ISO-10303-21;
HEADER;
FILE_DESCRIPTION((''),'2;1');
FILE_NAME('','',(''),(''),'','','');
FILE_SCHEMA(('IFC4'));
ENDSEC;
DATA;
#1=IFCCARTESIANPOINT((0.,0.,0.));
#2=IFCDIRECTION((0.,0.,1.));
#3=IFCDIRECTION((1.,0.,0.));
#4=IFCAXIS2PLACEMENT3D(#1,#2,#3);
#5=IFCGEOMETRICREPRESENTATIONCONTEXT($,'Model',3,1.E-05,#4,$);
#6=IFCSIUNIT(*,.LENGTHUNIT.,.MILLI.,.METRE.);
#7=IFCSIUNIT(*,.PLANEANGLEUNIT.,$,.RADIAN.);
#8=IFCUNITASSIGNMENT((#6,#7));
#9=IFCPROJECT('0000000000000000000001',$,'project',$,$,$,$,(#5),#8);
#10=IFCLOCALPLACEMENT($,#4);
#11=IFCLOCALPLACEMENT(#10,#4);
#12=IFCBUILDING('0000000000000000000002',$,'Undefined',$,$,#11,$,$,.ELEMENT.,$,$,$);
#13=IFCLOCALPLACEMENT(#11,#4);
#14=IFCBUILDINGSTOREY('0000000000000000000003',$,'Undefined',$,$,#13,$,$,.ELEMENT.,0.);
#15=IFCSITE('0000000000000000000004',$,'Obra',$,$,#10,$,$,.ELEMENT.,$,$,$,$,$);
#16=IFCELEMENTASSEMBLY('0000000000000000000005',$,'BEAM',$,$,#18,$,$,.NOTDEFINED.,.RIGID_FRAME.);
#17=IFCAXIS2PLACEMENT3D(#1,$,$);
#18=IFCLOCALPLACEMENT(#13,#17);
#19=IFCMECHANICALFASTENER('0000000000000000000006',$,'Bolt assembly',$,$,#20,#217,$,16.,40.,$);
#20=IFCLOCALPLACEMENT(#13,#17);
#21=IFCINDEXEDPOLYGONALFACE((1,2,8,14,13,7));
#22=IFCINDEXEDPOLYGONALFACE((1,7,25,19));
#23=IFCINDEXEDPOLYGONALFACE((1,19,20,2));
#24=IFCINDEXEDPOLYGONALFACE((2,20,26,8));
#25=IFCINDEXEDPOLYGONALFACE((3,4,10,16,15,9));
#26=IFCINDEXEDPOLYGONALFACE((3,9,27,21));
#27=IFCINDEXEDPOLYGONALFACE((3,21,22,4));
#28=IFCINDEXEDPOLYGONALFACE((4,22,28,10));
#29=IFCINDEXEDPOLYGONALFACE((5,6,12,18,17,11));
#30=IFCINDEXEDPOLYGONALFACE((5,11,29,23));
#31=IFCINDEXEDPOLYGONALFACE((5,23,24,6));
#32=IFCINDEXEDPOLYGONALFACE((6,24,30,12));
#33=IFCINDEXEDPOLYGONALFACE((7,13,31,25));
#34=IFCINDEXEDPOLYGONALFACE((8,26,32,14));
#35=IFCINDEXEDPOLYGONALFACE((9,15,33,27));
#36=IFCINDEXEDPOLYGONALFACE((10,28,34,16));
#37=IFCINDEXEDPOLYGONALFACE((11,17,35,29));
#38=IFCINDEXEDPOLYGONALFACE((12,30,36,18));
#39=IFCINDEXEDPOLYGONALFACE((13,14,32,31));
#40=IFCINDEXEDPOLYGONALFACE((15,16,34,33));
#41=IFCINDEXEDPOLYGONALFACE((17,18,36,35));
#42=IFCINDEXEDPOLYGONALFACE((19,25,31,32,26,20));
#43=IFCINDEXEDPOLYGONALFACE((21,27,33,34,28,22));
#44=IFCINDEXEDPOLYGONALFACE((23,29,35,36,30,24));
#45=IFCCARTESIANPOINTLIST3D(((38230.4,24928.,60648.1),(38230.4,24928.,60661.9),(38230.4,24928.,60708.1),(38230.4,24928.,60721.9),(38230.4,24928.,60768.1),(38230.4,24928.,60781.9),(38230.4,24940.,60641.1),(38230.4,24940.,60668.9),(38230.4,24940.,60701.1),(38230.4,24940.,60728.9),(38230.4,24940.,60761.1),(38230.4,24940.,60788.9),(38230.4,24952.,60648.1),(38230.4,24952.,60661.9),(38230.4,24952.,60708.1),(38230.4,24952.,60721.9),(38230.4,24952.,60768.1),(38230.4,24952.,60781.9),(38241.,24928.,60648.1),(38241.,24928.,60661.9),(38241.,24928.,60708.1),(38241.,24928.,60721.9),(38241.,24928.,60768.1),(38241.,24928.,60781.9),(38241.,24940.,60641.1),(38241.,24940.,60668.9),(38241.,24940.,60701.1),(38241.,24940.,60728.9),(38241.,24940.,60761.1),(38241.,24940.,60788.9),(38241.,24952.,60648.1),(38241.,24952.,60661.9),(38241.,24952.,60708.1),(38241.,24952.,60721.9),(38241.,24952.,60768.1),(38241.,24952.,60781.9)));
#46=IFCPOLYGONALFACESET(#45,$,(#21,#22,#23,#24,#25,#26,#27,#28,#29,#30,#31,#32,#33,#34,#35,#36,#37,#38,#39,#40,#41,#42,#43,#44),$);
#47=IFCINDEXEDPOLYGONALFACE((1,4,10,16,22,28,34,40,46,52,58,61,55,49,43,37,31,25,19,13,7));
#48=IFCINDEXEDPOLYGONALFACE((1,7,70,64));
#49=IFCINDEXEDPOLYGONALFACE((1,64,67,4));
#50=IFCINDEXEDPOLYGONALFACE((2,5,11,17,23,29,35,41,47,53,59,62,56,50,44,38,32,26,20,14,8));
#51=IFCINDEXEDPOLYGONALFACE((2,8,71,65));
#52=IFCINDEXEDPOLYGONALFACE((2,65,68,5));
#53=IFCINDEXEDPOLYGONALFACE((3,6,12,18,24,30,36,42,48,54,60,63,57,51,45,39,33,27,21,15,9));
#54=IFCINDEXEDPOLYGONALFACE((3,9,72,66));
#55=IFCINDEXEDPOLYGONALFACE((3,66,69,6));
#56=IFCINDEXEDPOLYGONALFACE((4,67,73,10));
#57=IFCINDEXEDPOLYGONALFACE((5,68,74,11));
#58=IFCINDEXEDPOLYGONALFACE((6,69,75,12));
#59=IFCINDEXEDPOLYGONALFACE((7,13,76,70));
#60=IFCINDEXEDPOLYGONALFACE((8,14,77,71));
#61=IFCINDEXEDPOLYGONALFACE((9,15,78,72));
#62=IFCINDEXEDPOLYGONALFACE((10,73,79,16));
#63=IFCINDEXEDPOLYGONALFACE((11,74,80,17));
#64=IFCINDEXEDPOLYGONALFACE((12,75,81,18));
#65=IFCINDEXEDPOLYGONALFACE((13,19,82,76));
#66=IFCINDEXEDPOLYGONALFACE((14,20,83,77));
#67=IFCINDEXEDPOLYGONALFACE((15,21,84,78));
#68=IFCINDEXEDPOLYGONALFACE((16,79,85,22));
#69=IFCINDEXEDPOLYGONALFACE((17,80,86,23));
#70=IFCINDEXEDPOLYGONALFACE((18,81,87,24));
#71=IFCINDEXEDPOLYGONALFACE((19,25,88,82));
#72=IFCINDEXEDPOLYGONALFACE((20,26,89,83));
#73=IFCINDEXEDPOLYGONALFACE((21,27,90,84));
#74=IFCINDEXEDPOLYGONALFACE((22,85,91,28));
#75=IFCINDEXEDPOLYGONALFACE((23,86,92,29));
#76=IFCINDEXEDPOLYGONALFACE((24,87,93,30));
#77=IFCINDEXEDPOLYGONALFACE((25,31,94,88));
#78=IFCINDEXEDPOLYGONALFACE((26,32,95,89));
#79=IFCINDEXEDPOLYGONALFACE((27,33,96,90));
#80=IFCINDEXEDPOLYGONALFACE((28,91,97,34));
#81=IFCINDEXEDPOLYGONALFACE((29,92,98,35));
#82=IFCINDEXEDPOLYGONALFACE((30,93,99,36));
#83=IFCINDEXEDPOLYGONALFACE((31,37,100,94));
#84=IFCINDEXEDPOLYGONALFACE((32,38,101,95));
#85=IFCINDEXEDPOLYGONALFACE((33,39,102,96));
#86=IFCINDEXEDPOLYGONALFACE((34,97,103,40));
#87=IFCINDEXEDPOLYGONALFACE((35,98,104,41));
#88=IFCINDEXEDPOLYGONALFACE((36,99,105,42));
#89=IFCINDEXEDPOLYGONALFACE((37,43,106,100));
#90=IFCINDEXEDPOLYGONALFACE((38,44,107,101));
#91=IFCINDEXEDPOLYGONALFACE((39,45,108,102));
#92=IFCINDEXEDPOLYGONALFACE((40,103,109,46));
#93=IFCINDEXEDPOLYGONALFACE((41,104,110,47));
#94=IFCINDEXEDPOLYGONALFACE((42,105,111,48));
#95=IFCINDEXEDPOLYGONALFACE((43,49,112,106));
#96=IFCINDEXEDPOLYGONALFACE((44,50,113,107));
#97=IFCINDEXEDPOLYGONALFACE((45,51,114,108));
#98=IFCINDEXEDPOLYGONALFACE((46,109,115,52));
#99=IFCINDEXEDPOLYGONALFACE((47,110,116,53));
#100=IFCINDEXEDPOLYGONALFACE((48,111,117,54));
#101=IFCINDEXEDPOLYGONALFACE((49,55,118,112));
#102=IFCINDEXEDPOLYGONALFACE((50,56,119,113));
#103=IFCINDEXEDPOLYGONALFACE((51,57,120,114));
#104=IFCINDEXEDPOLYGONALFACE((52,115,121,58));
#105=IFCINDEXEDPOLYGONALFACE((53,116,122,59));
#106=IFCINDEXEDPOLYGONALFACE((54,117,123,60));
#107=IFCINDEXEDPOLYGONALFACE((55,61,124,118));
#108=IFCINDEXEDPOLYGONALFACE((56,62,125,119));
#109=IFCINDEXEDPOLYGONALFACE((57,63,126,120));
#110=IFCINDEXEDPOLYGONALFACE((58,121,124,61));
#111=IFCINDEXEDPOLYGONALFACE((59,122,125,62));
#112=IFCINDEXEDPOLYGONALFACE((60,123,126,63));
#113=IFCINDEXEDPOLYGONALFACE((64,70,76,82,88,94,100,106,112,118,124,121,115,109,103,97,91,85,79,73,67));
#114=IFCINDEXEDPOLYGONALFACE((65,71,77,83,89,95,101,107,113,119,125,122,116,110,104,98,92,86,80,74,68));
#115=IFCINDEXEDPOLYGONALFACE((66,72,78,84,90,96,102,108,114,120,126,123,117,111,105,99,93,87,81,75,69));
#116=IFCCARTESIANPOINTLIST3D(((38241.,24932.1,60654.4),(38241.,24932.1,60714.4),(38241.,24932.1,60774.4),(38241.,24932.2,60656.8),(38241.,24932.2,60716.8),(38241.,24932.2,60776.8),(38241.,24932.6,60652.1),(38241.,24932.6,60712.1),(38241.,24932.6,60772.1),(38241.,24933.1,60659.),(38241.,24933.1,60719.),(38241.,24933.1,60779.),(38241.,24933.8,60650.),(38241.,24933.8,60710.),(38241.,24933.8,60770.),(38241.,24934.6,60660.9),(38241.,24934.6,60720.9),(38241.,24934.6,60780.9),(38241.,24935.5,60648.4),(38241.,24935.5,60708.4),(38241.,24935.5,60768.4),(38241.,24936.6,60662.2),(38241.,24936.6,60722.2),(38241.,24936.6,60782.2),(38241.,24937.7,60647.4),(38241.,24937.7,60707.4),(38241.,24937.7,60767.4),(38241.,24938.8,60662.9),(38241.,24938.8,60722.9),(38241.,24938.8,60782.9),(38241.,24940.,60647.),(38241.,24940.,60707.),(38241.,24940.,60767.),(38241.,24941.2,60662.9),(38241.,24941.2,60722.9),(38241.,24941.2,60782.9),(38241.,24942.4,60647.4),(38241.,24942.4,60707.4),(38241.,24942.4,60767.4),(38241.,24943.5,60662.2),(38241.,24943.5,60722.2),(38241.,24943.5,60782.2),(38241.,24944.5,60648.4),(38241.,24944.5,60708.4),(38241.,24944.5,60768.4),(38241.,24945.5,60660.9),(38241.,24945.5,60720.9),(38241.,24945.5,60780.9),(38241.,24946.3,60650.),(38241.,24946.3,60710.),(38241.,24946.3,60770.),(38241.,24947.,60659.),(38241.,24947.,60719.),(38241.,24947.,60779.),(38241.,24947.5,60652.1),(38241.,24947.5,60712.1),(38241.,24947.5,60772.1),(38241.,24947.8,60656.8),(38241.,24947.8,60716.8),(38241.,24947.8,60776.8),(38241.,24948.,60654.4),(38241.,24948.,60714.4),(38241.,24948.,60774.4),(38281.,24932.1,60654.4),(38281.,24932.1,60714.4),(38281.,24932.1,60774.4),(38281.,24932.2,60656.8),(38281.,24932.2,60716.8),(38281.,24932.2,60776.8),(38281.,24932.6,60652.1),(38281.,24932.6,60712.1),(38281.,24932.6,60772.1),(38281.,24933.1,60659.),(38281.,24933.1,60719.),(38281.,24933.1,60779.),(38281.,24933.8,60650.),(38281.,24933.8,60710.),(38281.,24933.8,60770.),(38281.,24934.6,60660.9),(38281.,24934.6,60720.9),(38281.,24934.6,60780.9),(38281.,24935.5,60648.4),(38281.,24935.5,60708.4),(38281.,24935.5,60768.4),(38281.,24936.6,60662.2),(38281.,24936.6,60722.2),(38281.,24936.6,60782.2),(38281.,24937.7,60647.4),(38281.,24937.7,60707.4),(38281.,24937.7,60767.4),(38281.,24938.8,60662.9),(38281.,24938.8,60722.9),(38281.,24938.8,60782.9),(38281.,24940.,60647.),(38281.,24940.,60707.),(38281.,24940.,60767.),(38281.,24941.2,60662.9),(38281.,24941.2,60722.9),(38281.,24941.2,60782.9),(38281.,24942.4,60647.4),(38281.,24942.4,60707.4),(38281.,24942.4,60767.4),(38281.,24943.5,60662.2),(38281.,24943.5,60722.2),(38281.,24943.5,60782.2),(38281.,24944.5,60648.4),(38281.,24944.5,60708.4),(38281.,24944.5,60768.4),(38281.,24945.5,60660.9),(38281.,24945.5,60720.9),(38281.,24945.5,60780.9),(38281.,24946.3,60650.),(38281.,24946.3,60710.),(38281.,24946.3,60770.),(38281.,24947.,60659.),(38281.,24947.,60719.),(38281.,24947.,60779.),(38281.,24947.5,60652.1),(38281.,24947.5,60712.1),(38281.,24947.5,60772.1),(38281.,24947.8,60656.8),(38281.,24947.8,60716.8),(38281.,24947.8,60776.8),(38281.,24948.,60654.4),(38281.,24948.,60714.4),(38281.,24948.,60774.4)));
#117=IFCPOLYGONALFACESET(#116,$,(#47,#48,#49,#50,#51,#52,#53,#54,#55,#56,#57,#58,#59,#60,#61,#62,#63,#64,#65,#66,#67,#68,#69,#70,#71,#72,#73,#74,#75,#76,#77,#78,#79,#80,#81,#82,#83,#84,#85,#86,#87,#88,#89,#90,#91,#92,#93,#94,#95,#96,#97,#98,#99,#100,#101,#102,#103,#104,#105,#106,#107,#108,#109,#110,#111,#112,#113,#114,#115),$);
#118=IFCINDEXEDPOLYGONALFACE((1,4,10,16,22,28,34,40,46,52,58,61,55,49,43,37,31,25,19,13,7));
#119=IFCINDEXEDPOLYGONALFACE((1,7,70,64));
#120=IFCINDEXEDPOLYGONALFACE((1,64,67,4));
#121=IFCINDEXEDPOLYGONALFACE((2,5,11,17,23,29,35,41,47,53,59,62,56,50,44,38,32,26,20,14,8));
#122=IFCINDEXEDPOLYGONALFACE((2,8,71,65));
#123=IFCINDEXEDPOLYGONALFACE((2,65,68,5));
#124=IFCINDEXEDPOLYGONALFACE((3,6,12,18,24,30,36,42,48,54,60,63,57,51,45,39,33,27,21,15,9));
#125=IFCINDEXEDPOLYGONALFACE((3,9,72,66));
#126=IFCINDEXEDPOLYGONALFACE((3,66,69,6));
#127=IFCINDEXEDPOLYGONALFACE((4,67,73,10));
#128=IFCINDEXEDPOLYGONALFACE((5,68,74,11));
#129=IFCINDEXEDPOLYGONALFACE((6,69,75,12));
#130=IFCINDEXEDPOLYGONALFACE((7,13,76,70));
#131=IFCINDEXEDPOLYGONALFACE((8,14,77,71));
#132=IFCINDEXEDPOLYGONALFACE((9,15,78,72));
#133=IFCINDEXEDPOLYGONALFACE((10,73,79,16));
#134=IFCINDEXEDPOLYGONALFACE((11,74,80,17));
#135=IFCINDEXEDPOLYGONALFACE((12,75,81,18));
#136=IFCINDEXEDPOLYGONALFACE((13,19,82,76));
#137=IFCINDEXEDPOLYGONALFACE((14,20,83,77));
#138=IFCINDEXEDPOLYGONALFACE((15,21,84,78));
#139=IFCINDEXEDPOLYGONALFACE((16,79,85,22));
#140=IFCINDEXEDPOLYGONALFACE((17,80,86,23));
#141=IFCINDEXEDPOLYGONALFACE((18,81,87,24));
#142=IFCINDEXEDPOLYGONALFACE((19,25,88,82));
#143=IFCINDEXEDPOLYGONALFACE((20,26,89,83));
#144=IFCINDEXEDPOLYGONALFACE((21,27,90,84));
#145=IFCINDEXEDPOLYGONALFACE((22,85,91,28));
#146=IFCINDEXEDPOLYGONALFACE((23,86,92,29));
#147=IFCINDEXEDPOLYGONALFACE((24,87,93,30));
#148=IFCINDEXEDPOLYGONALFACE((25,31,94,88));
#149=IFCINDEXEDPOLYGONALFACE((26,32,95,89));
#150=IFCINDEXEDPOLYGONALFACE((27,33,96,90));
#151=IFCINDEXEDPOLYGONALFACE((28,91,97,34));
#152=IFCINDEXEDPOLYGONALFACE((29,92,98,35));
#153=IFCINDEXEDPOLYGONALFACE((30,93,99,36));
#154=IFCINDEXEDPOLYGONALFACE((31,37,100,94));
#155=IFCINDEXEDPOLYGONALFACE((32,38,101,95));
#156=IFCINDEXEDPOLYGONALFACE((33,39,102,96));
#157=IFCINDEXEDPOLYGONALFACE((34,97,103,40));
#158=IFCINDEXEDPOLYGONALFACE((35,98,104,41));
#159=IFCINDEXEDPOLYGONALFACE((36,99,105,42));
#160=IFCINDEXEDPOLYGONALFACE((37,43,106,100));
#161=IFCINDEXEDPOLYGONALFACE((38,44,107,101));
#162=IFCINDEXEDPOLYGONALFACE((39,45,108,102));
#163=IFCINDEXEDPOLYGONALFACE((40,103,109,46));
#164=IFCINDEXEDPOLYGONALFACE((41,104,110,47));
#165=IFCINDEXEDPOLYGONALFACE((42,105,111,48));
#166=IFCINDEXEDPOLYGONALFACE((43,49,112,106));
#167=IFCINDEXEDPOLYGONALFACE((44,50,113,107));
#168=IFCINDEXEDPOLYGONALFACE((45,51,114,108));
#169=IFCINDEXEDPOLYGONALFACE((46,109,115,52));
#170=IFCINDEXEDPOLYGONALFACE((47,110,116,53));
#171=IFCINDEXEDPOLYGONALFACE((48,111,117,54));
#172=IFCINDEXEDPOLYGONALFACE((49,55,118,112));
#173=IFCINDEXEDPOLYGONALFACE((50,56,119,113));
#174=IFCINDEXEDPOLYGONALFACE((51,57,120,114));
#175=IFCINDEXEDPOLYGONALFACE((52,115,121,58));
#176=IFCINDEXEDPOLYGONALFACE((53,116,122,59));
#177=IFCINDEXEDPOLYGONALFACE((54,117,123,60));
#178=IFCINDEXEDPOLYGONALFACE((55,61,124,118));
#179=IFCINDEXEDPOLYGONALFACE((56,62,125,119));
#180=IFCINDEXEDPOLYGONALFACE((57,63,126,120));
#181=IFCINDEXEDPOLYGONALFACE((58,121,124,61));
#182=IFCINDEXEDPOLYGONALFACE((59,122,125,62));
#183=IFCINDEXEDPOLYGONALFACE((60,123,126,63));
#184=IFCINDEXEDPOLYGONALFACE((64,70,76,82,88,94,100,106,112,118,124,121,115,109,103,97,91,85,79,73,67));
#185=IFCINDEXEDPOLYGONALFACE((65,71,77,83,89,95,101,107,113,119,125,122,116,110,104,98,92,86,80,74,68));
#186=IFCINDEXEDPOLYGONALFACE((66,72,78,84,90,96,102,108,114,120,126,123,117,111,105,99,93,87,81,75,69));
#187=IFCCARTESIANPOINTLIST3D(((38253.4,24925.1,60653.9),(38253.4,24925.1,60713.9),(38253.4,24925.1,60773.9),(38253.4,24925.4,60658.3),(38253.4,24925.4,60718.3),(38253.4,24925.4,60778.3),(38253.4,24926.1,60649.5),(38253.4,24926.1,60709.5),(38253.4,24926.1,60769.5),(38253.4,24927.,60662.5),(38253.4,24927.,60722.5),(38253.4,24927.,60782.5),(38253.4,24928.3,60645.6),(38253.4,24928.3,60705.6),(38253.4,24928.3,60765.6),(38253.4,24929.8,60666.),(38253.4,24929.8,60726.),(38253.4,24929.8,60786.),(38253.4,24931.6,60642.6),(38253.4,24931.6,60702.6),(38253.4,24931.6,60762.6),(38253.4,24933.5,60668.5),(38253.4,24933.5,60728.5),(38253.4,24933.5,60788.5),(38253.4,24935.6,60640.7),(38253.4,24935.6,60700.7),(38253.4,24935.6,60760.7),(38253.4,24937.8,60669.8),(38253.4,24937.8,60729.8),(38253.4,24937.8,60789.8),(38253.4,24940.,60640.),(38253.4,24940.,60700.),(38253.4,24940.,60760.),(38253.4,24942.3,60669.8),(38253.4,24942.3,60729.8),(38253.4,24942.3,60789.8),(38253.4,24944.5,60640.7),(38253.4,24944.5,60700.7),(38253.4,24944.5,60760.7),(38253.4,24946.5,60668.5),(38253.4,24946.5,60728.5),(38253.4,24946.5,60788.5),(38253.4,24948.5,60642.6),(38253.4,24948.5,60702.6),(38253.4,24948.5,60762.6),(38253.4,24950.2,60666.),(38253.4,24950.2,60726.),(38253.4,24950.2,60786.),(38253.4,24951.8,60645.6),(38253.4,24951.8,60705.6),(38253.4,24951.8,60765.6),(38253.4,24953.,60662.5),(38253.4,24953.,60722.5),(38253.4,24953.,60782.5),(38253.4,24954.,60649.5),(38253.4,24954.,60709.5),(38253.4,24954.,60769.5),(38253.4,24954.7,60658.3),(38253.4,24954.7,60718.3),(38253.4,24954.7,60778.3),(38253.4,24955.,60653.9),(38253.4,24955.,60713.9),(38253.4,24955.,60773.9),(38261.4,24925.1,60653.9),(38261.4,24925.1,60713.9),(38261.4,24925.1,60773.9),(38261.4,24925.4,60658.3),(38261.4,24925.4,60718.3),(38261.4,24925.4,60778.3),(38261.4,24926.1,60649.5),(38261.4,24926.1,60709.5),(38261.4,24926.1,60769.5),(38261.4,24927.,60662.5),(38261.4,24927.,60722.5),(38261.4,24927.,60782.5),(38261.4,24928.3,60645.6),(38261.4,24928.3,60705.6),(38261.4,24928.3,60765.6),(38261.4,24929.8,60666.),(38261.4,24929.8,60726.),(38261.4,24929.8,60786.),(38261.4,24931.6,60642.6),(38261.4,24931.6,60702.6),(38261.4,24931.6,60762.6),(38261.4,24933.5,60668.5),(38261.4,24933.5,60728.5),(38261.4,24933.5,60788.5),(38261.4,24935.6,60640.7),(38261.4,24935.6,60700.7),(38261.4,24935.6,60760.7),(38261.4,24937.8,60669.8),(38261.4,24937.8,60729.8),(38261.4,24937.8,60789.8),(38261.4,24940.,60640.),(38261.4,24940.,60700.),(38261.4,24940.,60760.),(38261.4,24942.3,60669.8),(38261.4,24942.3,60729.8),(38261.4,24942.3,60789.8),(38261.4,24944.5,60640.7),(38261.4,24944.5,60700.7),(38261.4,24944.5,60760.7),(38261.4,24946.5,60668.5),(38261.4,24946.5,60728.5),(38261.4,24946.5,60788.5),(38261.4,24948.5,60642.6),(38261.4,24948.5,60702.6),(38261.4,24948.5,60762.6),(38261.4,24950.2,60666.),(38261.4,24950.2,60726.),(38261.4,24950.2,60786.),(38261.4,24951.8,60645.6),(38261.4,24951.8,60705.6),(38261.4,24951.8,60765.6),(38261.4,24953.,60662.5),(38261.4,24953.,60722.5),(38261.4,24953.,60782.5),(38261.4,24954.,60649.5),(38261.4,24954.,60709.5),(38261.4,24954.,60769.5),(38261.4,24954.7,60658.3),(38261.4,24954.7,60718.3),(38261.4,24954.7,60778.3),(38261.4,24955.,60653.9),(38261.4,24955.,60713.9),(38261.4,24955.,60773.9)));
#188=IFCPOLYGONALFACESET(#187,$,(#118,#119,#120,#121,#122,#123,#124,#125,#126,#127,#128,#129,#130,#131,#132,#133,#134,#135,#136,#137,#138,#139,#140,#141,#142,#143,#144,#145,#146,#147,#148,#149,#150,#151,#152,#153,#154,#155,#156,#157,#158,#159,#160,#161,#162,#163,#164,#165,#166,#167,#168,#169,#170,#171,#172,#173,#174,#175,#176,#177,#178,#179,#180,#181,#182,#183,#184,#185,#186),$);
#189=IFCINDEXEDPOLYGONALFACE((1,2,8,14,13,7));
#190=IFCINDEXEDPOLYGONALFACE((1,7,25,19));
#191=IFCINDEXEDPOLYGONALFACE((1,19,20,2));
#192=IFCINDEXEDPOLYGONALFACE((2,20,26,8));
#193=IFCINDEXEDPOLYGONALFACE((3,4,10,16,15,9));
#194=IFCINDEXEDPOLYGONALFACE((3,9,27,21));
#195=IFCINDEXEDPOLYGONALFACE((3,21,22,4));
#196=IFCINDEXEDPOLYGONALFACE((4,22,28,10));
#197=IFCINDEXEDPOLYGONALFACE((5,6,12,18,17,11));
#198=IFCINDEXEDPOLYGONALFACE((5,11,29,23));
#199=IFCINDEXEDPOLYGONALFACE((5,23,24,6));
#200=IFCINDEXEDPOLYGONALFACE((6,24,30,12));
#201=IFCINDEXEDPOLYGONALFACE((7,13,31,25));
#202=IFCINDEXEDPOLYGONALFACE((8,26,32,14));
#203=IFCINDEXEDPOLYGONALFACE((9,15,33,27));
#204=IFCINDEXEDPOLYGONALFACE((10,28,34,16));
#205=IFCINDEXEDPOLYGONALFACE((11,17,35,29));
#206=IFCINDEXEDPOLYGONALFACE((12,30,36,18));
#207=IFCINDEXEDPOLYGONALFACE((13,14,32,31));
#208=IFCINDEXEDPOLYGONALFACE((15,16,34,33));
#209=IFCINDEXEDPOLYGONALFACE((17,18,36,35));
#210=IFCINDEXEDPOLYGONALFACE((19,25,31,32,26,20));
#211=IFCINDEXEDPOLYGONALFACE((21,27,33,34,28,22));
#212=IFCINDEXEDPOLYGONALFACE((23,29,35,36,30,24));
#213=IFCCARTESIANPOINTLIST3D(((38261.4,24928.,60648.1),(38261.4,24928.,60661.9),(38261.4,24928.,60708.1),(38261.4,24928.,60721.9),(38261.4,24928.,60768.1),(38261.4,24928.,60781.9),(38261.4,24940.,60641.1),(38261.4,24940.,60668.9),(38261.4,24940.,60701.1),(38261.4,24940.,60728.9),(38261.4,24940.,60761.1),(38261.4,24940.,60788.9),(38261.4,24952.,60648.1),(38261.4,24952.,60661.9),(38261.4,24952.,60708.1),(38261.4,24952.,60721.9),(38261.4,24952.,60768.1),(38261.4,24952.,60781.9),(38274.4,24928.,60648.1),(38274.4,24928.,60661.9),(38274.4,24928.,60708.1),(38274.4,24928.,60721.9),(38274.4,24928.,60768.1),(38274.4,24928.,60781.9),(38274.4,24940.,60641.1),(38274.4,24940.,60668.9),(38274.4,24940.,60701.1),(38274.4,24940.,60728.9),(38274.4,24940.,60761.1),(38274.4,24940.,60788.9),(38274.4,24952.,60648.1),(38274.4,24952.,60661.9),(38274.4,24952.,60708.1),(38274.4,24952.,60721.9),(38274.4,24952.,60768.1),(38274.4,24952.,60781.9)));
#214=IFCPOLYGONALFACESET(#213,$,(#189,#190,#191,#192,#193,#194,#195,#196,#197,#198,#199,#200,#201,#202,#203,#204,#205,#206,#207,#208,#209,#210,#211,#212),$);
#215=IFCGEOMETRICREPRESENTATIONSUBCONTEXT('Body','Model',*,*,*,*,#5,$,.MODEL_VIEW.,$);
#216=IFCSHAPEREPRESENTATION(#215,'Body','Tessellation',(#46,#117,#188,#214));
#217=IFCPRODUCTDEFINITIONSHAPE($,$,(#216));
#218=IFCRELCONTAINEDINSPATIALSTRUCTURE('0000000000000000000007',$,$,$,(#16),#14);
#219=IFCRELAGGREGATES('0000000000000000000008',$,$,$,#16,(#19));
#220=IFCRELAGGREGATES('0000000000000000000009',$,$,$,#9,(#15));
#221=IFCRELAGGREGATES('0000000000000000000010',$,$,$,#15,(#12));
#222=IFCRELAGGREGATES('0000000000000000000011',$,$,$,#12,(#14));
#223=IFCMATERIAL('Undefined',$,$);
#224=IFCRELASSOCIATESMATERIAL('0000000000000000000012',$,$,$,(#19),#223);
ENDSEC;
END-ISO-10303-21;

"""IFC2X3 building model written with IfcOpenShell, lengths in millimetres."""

from ifc_helpers import new_model, si_unit, frame, origin_with_axes, origin_2d_with_axis, place, context, subcontext, project, spatial, polyline, circle, outline, extrude, source, transform, mapped, material, element, aggregate, save


model = new_model("IFC2X3")

# Units and contexts
model_context = context("Model", 3, precision=1e-05, world=origin_with_axes())
body_context = subcontext(model_context, "Body", "Model", "MODEL_VIEW")
ifc_project = project(units=[si_unit("LENGTHUNIT", "METRE", prefix="MILLI"), si_unit("PLANEANGLEUNIT", "RADIAN")], contexts=[model_context])

# Site, building, storey
site_placement = place(None, origin_with_axes())
site = spatial("IfcSite", under=ifc_project, at=site_placement, Name="Obra", CompositionType="ELEMENT")
building_placement = place(site_placement, origin_with_axes())
building = spatial("IfcBuilding", under=site, at=building_placement, Name="Undefined", CompositionType="ELEMENT")
storey_placement = place(building_placement, origin_with_axes())
storey = spatial("IfcBuildingStorey", under=building, at=storey_placement, Name="Undefined", CompositionType="ELEMENT", Elevation=0.0)

# Element assembly
ifc_material_1 = material(Name="Undefined")
assembly_1_placement = place(storey_placement, origin_with_axes())
assembly_1 = element("IfcElementAssembly", 1, at=assembly_1_placement, inside=storey, Name="BEAM", AssemblyPlace="NOTDEFINED", PredefinedType="RIGID_FRAME")

# Mechanical fastener
shared_shape_1 = source(origin_with_axes(), body_context, "Body", "SweptSolid", [
    extrude(outline(polyline([(13.9, 0.0), (6.9, 12.0), (-6.9, 12.0), (-13.9, 0.0), (-6.9, -12.0), (6.9, -12.0), (13.9, 0.0)])), frame((0.0, -19.7, 0.0), z_axis=(0.0, 1.0, 0.0), x_axis=(1.0, 0.0, 0.0)), (0.0, 0.0, 1.0), 10.6),
    extrude(circle(Radius=8.0, at=origin_2d_with_axis()), frame((0.0, -9.1, 0.0), z_axis=(0.0, 1.0, 0.0), x_axis=(1.0, 0.0, 0.0)), (0.0, 0.0, 1.0), 40.0),
    extrude(circle(Radius=15.0, at=origin_2d_with_axis()), frame((0.0, 3.3, 0.0), z_axis=(0.0, 1.0, 0.0), x_axis=(1.0, 0.0, 0.0)), (0.0, 0.0, 1.0), 8.0),
    extrude(outline(polyline([(13.9, 0.0), (6.9, 12.0), (-6.9, 12.0), (-13.9, 0.0), (-6.9, -12.0), (6.9, -12.0), (13.9, 0.0)])), frame((0.0, 11.3, 0.0), z_axis=(0.0, 1.0, 0.0), x_axis=(1.0, 0.0, 0.0)), (0.0, 0.0, 1.0), 13.0),
])
mechanical_fastener_1_placement = place(assembly_1_placement, frame((38250.1, 24990.0, 60835.0), z_axis=(0.000002, -1.0, 0.0), x_axis=(0.0, 0.0, -1.0)))
mechanical_fastener_1 = element("IfcMechanicalFastener", 2, at=mechanical_fastener_1_placement, material=ifc_material_1, Name="Bolt assembly", NominalDiameter=16.0, NominalLength=40.0, context=body_context, shape_type="MappedRepresentation", body=[
    mapped(shared_shape_1, transform((60.0, 0.0, 50.0))),
    mapped(shared_shape_1, transform((120.0, 0.0, 50.0))),
    mapped(shared_shape_1, transform((180.0, 0.0, 50.0))),
])
aggregate(assembly_1, [mechanical_fastener_1])

save(model, "model.ifc")
